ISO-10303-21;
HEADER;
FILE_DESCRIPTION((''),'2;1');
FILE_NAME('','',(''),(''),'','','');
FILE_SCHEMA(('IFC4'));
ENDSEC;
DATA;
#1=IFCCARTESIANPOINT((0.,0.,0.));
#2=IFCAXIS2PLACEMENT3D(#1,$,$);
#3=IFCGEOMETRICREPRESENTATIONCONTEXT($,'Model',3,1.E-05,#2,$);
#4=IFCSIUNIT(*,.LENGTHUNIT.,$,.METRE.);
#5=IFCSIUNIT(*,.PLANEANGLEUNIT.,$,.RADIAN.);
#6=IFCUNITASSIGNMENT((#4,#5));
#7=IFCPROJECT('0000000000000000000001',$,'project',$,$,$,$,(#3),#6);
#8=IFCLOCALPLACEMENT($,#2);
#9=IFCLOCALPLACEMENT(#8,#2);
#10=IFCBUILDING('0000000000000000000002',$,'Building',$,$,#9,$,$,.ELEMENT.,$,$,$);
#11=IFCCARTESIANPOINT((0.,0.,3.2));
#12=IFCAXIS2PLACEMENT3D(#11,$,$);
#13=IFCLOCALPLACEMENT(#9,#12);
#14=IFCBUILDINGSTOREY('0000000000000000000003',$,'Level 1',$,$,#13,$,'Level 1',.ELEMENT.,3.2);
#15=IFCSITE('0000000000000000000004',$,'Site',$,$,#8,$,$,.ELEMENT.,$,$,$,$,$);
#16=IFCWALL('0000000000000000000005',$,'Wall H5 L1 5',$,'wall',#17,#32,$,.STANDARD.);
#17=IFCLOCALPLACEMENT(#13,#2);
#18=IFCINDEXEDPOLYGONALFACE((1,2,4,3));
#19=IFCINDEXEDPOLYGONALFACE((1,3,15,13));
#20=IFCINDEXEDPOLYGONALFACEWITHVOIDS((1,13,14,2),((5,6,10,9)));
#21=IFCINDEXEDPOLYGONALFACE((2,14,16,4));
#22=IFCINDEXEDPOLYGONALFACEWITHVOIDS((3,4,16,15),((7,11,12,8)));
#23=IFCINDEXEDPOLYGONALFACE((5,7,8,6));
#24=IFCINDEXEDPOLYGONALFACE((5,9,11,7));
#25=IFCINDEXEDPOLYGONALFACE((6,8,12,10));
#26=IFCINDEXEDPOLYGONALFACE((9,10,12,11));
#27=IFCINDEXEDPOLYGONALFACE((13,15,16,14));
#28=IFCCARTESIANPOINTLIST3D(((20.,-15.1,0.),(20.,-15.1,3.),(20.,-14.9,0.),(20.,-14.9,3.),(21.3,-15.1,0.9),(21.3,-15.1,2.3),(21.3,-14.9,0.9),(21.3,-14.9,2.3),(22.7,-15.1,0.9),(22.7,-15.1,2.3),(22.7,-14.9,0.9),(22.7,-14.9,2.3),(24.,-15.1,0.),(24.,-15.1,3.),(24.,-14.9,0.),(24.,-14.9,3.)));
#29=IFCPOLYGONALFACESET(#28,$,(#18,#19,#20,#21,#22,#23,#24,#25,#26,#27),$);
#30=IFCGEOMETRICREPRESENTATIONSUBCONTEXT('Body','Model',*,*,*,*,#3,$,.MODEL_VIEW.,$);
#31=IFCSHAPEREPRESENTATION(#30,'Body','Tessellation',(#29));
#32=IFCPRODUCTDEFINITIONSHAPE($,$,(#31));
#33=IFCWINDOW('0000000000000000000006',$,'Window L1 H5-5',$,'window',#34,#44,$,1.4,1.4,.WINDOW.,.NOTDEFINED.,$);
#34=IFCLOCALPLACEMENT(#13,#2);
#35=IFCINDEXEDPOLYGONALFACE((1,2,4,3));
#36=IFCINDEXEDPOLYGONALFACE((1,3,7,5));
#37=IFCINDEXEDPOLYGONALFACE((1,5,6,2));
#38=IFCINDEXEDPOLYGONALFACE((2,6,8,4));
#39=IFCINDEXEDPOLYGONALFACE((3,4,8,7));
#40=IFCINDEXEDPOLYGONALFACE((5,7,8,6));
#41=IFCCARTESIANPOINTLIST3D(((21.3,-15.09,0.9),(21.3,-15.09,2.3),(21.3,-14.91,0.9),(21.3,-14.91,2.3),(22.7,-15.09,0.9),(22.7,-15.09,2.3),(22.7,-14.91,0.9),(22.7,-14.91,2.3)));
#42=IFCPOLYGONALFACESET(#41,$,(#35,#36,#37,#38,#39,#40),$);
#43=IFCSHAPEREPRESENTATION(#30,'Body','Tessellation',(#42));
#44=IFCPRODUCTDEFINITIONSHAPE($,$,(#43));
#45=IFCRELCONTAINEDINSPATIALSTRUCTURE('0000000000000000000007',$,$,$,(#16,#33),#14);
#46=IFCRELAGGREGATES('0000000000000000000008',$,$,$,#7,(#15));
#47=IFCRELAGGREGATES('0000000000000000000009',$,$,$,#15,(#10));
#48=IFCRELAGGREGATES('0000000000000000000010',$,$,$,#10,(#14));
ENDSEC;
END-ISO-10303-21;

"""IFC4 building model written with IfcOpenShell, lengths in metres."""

from ifc_helpers import new_model, si_unit, frame, frame_2d, origin, origin_2d, place, context, subcontext, project, spatial, rectangle, extrude, element, fill, save


model = new_model("IFC4")

# Units and contexts
model_context = context("Model", 3, precision=1e-05, world=origin())
body_context = subcontext(model_context, "Body", "Model", "MODEL_VIEW")
ifc_project = project(units=[si_unit("LENGTHUNIT", "METRE"), si_unit("PLANEANGLEUNIT", "RADIAN")], contexts=[model_context])

# Site, building, storey
site_placement = place(None, origin())
site = spatial("IfcSite", under=ifc_project, at=site_placement, Name="Site", CompositionType="ELEMENT")
building_placement = place(site_placement, origin())
building = spatial("IfcBuilding", under=site, at=building_placement, Name="Building", CompositionType="ELEMENT")
storey_placement = place(building_placement, frame((0.0, 0.0, 3.2)))
storey = spatial("IfcBuildingStorey", under=building, at=storey_placement, Name="Level 1", LongName="Level 1", CompositionType="ELEMENT", Elevation=3.2)

# Wall, opening, window
wall_1_placement = place(storey_placement, frame((20.0, -15.0, 0.0), z_axis=(0.0, 0.0, 1.0), x_axis=(1.0, 0.0, 0.0)))
wall_1 = element("IfcWall", 1, at=wall_1_placement, inside=storey, Name="Wall H5 L1 5", ObjectType="wall", PredefinedType="STANDARD", context=body_context, shape_type="SweptSolid", body=[
    extrude(rectangle(XDim=4.0, YDim=0.2, at=frame_2d((2.0, 0.0))), origin(), (0.0, 0.0, 1.0), 3.0),
])
opening_1_placement = place(storey_placement, frame((22.0, -15.0, 0.9), z_axis=(0.0, 0.0, 1.0), x_axis=(1.0, 0.0, 0.0)))
opening_1 = element("IfcOpeningElement", 2, at=opening_1_placement, cuts=wall_1, ObjectType="Opening", PredefinedType="OPENING", context=body_context, shape_type="SweptSolid", body=[
    extrude(rectangle(XDim=1.4, YDim=0.22, at=origin_2d()), origin(), (0.0, 0.0, 1.0), 1.4),
])
window_1_placement = place(storey_placement, frame((22.0, -15.0, 0.9), z_axis=(0.0, 0.0, 1.0), x_axis=(1.0, 0.0, 0.0)))
window_1 = element("IfcWindow", 3, at=window_1_placement, inside=storey, Name="Window L1 H5-5", ObjectType="window", OverallHeight=1.4, OverallWidth=1.4, PartitioningType="NOTDEFINED", PredefinedType="WINDOW", context=body_context, shape_type="SweptSolid", body=[
    extrude(rectangle(XDim=1.4, YDim=0.18, at=origin_2d()), origin(), (0.0, 0.0, 1.0), 1.4),
])
fill(opening_1, window_1)

save(model, "model.ifc")
